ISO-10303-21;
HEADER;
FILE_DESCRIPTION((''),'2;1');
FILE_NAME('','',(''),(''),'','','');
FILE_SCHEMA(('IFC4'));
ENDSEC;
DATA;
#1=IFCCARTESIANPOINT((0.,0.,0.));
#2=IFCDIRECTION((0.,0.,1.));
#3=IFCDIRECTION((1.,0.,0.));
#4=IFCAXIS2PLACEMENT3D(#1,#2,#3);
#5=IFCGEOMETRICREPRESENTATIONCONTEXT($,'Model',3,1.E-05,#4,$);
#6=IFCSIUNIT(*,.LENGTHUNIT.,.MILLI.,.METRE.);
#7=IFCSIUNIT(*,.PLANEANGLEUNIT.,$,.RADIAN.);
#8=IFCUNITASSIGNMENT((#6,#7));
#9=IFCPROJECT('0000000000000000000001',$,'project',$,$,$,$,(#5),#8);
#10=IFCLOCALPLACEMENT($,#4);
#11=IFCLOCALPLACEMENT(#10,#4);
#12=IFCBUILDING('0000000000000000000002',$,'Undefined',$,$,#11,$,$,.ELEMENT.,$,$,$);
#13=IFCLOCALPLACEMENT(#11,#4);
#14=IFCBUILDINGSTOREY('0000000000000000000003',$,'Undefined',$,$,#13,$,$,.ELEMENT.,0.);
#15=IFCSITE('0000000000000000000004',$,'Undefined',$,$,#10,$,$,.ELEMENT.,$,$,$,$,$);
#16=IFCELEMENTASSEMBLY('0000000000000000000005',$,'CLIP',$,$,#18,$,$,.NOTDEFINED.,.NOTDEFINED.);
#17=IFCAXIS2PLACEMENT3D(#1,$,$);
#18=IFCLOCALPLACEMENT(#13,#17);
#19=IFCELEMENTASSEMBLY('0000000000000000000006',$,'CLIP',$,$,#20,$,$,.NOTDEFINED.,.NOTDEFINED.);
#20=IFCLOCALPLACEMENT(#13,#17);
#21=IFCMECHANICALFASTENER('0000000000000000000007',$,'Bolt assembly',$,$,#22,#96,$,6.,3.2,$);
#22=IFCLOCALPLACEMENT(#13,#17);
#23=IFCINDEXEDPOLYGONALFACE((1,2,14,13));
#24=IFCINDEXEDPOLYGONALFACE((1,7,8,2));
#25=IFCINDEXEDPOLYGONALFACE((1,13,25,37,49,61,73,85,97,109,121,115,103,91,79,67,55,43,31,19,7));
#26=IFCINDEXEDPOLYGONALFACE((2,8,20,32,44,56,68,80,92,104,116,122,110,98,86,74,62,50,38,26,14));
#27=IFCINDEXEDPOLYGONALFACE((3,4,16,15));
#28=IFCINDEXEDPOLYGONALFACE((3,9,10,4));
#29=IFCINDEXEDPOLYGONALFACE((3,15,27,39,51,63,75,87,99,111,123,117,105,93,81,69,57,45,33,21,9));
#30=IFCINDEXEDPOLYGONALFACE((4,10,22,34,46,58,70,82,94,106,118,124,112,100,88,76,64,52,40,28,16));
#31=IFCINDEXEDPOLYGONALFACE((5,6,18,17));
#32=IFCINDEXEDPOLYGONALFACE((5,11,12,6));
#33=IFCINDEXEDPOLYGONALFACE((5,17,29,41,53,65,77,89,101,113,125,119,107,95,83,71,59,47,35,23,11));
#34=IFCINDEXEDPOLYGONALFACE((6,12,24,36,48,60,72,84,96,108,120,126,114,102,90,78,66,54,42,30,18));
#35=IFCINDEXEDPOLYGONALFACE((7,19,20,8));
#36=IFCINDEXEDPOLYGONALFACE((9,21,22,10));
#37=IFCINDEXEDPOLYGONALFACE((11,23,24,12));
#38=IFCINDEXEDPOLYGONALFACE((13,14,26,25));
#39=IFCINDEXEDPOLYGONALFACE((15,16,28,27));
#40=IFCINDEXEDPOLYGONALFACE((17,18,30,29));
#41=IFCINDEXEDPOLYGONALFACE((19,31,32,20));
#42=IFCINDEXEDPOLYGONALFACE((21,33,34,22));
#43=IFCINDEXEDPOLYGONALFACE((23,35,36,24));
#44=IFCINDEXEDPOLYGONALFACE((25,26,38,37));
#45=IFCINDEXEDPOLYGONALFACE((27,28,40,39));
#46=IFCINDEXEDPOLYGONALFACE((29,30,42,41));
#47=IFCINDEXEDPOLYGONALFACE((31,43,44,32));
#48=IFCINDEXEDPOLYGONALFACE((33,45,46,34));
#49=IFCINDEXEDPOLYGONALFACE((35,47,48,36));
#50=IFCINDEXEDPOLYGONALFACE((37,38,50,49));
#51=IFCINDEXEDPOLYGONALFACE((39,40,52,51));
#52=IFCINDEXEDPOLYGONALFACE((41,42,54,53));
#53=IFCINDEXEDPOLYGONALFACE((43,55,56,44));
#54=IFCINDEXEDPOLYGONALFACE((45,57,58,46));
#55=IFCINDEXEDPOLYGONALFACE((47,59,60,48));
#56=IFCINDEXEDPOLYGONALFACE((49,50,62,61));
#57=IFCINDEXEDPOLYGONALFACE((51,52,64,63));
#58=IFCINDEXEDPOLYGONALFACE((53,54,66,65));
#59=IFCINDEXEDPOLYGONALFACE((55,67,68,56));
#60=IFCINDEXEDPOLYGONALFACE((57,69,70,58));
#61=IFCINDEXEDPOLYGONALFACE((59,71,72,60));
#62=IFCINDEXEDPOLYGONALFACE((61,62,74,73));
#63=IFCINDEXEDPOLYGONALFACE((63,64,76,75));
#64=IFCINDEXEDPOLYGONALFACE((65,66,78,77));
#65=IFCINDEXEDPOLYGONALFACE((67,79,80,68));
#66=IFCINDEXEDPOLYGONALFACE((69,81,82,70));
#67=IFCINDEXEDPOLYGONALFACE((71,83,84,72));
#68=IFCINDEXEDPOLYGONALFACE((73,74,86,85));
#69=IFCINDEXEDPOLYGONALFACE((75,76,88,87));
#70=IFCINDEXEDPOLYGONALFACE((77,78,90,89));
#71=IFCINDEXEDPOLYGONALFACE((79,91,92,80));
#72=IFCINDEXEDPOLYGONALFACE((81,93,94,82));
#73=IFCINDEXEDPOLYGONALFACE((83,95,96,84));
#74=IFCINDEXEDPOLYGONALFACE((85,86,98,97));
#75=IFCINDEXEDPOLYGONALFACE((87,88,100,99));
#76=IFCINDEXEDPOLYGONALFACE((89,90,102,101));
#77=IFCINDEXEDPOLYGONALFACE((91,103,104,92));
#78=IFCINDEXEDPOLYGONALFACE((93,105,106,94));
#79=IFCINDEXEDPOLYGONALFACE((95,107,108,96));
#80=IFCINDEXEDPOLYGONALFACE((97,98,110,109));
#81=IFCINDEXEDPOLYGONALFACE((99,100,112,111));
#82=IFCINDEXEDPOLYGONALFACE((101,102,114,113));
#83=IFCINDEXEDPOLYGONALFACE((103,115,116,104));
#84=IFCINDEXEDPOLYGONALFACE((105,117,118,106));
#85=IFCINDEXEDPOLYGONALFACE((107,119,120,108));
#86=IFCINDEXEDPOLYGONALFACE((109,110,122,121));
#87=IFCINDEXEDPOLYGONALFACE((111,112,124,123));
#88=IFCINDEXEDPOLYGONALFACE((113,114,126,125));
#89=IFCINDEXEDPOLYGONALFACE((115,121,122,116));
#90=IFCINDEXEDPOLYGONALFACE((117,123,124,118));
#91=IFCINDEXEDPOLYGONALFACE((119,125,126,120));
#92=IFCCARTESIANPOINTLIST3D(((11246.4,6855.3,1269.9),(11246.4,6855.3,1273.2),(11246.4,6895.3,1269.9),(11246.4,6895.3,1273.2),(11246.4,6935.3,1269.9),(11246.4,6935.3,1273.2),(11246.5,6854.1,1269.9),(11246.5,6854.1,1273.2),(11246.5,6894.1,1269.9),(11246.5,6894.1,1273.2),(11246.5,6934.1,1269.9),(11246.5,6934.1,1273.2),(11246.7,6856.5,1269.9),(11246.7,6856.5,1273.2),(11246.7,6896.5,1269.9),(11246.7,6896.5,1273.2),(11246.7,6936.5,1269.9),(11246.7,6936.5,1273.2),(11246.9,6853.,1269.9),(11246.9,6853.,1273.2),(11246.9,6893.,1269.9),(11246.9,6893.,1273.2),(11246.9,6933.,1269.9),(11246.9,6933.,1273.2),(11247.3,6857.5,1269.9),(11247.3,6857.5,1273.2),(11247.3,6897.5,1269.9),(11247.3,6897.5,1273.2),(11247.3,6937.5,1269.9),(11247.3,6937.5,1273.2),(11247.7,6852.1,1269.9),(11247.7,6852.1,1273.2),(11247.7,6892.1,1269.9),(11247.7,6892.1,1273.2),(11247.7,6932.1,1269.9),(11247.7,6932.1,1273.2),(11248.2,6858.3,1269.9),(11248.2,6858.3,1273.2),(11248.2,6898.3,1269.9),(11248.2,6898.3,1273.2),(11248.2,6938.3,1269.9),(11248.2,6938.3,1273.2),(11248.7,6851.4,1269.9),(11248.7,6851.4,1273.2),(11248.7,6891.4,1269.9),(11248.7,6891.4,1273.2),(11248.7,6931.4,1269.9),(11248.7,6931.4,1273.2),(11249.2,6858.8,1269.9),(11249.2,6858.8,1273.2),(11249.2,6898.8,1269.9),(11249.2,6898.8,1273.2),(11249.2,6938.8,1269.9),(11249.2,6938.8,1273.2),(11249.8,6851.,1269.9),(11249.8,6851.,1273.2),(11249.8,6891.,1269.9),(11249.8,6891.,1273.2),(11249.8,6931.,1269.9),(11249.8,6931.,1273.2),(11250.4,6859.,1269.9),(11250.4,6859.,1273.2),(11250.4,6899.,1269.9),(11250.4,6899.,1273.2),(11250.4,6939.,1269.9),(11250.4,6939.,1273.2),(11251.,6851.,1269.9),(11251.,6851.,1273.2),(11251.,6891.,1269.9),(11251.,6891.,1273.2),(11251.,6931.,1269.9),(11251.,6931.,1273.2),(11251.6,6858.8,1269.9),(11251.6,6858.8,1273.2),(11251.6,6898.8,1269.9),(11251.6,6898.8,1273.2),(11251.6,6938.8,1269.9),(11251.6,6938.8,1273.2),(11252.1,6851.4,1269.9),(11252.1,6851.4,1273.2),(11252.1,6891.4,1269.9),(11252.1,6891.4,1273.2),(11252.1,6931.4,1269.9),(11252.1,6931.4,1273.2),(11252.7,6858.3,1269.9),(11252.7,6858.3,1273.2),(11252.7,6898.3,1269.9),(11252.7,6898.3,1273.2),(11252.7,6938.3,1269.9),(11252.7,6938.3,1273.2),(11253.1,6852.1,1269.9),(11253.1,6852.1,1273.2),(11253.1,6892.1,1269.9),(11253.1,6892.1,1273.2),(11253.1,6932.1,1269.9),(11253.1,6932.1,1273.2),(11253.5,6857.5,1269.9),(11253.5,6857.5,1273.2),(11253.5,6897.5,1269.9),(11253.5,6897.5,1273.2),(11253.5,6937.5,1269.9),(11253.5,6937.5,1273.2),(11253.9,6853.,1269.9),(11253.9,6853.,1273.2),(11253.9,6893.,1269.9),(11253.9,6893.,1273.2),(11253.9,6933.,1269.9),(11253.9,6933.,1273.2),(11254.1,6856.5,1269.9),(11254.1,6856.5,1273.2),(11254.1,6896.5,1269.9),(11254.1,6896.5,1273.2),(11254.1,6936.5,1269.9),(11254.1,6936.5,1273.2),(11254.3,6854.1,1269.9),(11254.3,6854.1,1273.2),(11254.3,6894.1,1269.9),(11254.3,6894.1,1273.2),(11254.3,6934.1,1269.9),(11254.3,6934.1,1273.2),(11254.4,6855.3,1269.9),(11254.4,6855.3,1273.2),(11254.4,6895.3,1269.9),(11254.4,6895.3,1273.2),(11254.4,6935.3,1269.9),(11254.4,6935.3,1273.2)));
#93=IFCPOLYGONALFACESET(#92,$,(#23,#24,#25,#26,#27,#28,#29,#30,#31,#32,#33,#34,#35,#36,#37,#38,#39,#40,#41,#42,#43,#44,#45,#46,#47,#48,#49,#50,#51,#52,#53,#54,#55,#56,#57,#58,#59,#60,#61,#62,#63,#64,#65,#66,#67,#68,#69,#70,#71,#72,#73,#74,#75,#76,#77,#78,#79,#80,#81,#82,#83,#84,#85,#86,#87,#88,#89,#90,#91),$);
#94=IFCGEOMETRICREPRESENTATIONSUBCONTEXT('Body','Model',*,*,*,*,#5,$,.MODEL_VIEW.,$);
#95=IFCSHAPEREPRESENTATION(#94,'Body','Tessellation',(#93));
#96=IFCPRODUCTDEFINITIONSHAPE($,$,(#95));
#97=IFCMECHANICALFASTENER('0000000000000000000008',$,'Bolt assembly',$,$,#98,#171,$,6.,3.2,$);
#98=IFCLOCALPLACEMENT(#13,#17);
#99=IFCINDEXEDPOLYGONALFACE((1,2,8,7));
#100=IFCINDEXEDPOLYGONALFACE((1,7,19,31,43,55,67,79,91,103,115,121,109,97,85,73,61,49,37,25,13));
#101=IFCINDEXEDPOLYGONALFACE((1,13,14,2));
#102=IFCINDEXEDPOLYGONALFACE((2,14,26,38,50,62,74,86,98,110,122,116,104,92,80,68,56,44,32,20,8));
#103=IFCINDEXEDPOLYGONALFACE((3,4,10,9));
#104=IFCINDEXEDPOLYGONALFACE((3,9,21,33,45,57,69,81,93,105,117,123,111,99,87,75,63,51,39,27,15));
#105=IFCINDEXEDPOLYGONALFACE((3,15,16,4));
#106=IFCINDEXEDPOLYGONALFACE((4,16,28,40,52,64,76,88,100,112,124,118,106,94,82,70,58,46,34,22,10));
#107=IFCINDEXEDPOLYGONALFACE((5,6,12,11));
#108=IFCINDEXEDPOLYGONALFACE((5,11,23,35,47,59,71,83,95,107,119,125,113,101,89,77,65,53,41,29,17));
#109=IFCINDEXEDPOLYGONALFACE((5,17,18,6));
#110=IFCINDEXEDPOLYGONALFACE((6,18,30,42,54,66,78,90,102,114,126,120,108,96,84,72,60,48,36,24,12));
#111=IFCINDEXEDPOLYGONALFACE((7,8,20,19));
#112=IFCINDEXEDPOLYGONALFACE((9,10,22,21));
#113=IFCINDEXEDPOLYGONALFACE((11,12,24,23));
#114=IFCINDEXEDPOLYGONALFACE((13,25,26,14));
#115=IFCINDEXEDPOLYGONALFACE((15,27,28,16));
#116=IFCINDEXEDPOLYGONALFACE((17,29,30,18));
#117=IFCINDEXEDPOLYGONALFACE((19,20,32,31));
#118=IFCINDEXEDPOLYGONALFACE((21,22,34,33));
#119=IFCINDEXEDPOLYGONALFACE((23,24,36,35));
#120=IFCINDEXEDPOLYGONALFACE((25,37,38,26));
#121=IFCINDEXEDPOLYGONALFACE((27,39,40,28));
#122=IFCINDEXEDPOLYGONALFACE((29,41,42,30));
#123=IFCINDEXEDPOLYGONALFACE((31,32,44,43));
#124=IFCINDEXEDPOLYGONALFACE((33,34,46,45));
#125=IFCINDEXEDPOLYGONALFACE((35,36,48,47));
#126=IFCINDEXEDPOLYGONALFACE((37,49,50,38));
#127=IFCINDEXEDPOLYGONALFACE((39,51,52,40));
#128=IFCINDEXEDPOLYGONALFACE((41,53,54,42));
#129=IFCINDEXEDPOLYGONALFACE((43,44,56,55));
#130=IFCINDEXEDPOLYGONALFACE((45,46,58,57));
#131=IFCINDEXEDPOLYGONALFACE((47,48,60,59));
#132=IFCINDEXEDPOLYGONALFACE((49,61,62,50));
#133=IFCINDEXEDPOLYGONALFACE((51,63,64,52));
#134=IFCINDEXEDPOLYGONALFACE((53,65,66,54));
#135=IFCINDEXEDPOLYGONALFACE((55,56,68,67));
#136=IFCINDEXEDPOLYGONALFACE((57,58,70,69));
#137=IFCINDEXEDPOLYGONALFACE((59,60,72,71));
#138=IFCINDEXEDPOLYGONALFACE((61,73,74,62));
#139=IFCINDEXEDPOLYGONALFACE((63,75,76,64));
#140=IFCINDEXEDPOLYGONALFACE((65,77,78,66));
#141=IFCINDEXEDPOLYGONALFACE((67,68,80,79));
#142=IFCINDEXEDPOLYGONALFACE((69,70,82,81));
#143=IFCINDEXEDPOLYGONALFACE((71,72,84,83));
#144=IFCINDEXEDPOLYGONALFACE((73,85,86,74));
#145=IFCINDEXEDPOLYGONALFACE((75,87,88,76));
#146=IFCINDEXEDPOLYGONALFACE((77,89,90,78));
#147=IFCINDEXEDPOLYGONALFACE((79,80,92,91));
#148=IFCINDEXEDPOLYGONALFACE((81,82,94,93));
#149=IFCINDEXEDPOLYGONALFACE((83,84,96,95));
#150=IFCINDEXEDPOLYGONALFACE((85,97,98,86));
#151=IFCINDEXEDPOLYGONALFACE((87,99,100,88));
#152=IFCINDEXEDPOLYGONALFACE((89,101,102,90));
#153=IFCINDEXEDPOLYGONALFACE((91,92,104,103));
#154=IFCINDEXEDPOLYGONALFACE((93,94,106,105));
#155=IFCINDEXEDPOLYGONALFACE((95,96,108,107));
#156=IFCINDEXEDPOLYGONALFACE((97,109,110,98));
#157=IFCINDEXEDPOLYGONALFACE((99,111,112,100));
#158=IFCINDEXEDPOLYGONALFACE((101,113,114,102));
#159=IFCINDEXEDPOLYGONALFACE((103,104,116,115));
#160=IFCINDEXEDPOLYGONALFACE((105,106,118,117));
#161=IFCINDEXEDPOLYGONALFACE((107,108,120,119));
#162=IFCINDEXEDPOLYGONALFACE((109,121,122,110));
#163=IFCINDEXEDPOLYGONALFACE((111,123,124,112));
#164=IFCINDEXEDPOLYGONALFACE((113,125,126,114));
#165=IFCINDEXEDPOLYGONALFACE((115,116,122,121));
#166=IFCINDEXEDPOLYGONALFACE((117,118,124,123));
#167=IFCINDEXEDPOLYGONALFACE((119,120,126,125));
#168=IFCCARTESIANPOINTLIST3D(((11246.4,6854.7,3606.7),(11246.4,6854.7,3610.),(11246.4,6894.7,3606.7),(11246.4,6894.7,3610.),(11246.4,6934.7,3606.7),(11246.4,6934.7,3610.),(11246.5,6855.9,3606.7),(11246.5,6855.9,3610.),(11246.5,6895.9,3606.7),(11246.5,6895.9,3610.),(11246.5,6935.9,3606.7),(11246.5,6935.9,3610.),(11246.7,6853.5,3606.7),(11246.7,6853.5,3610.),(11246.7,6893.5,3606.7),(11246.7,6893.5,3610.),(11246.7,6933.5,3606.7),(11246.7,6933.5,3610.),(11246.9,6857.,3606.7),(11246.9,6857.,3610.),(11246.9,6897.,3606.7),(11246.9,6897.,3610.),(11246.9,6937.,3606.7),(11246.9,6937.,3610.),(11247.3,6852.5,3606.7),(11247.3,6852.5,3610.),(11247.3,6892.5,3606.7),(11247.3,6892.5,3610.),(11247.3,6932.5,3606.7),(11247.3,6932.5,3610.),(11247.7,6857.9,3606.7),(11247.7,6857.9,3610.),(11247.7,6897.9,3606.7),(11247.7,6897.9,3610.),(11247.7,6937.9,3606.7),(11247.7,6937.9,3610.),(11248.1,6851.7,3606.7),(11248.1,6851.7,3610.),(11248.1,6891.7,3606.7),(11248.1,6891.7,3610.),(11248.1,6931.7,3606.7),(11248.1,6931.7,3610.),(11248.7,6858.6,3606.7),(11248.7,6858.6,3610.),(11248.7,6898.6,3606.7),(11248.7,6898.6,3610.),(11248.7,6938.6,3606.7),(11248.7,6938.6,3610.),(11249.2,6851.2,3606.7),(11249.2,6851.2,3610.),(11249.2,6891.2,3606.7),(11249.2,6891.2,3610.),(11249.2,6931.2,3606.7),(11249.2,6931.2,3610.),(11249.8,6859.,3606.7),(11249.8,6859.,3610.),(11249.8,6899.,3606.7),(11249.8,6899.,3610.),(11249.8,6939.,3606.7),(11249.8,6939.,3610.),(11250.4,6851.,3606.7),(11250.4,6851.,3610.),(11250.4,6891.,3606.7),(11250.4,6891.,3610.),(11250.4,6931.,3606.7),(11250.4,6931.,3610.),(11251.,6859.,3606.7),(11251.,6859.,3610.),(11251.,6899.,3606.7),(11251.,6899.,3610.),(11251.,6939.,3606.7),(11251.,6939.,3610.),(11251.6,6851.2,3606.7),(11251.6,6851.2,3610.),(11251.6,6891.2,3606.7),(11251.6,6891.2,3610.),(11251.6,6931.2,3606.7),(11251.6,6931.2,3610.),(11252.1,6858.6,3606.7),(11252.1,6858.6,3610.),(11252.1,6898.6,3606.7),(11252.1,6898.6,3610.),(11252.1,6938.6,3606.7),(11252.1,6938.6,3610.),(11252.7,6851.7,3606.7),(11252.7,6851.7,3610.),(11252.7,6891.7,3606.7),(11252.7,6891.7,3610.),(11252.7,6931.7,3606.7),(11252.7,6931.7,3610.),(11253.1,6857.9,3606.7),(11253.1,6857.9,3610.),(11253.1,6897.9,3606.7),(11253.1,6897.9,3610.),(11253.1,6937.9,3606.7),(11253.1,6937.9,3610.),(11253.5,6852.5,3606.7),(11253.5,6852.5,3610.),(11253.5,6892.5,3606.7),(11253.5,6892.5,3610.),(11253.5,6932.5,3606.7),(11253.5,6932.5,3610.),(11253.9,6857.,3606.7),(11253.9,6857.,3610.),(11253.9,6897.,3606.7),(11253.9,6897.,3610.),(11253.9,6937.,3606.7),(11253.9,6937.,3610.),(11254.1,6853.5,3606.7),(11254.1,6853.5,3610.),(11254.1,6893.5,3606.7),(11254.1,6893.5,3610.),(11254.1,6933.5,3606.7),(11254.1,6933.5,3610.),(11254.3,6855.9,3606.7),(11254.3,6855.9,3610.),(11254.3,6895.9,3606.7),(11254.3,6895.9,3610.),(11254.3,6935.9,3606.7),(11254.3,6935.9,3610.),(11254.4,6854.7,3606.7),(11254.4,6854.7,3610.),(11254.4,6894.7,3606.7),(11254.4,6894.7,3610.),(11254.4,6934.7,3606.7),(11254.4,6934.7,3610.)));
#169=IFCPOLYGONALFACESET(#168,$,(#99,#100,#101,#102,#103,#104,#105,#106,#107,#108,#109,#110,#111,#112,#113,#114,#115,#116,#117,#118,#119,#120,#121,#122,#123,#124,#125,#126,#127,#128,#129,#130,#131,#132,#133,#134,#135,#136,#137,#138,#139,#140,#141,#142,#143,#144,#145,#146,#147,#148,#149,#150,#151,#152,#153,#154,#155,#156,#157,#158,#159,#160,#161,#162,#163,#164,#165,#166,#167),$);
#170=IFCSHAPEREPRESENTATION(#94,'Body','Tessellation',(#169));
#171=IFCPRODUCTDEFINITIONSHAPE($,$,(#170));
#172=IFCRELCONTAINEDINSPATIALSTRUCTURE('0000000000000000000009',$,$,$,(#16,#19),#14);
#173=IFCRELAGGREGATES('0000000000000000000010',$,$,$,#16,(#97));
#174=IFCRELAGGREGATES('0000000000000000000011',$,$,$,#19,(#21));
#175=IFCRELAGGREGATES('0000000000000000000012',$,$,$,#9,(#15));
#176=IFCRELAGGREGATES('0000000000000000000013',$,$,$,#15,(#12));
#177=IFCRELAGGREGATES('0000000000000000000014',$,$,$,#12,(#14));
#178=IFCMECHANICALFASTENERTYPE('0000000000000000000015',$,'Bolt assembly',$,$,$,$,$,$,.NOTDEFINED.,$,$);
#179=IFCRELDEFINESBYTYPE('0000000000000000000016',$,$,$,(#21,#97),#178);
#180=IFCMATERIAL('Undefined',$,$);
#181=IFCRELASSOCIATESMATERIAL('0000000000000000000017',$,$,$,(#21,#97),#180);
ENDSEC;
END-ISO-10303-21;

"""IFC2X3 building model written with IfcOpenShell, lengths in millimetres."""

from ifc_helpers import new_model, si_unit, frame, origin_with_axes, origin_2d_with_axis, place, context, subcontext, project, spatial, circle, extrude, source, transform, mapped, material, type_object, element, aggregate, save


model = new_model("IFC2X3")

# Units and contexts
model_context = context("Model", 3, precision=1e-05, world=origin_with_axes())
body_context = subcontext(model_context, "Body", "Model", "MODEL_VIEW")
ifc_project = project(units=[si_unit("LENGTHUNIT", "METRE", prefix="MILLI"), si_unit("PLANEANGLEUNIT", "RADIAN")], contexts=[model_context])

# Site, building, storey
site_placement = place(None, origin_with_axes())
site = spatial("IfcSite", under=ifc_project, at=site_placement, Name="Undefined", CompositionType="ELEMENT")
building_placement = place(site_placement, origin_with_axes())
building = spatial("IfcBuilding", under=site, at=building_placement, Name="Undefined", CompositionType="ELEMENT")
storey_placement = place(building_placement, origin_with_axes())
storey = spatial("IfcBuildingStorey", under=building, at=storey_placement, Name="Undefined", CompositionType="ELEMENT", Elevation=0.0)

# Element assemblies
assembly_1_placement = place(storey_placement, origin_with_axes())
assembly_1 = element("IfcElementAssembly", 1, at=assembly_1_placement, inside=storey, Name="CLIP", AssemblyPlace="NOTDEFINED", PredefinedType="NOTDEFINED")
assembly_2_placement = place(storey_placement, origin_with_axes())
assembly_2 = element("IfcElementAssembly", 2, at=assembly_2_placement, inside=storey, Name="CLIP", AssemblyPlace="NOTDEFINED", PredefinedType="NOTDEFINED")

# Mechanical fasteners
ifc_material_1 = material(Name="Undefined")
mechanical_fastener_type = type_object("IfcMechanicalFastenerType", Name="Bolt assembly")
shared_shape_1 = source(origin_with_axes(), body_context, "Body", "SweptSolid", [
    extrude(circle(Radius=4.0, at=origin_2d_with_axis()), frame((0.0, -3.2, 0.0), z_axis=(0.0, 1.0, 0.0), x_axis=(1.0, 0.0, 0.0)), (0.0, 0.0, 1.0), 3.3),
])
mechanical_fastener_1_placement = place(assembly_2_placement, frame((11250.4, 6855.0, 1270.0), z_axis=(-1.0, 0.0, 0.0), x_axis=(0.0, 1.0, 0.0)))
mechanical_fastener_1 = element("IfcMechanicalFastener", 3, at=mechanical_fastener_1_placement, type_object=mechanical_fastener_type, material=ifc_material_1, Name="Bolt assembly", NominalDiameter=6.0, NominalLength=3.2, context=body_context, shape_type="MappedRepresentation", body=[
    mapped(shared_shape_1, transform((0.0, 0.0, 0.0))),
    mapped(shared_shape_1, transform((40.0, 0.0, 0.0))),
    mapped(shared_shape_1, transform((80.0, 0.0, 0.0))),
])
shared_shape_2 = source(origin_with_axes(), body_context, "Body", "SweptSolid", [
    extrude(circle(Radius=4.0, at=origin_2d_with_axis()), frame((0.0, 0.0, 0.0), z_axis=(0.0, 1.0, 0.0), x_axis=(1.0, 0.0, 0.0)), (0.0, 0.0, 1.0), 3.3),
])
mechanical_fastener_2_placement = place(assembly_1_placement, frame((11250.4, 6935.0, 3610.0), z_axis=(1.0, 0.0, 0.0), x_axis=(0.0, -1.0, 0.0)))
mechanical_fastener_2 = element("IfcMechanicalFastener", 4, at=mechanical_fastener_2_placement, type_object=mechanical_fastener_type, material=ifc_material_1, Name="Bolt assembly", NominalDiameter=6.0, NominalLength=3.2, context=body_context, shape_type="MappedRepresentation", body=[
    mapped(shared_shape_2, transform((0.0, 0.0, 0.0))),
    mapped(shared_shape_2, transform((40.0, 0.0, 0.0))),
    mapped(shared_shape_2, transform((80.0, 0.0, 0.0))),
])
aggregate(assembly_1, [mechanical_fastener_2])
aggregate(assembly_2, [mechanical_fastener_1])

save(model, "model.ifc")
